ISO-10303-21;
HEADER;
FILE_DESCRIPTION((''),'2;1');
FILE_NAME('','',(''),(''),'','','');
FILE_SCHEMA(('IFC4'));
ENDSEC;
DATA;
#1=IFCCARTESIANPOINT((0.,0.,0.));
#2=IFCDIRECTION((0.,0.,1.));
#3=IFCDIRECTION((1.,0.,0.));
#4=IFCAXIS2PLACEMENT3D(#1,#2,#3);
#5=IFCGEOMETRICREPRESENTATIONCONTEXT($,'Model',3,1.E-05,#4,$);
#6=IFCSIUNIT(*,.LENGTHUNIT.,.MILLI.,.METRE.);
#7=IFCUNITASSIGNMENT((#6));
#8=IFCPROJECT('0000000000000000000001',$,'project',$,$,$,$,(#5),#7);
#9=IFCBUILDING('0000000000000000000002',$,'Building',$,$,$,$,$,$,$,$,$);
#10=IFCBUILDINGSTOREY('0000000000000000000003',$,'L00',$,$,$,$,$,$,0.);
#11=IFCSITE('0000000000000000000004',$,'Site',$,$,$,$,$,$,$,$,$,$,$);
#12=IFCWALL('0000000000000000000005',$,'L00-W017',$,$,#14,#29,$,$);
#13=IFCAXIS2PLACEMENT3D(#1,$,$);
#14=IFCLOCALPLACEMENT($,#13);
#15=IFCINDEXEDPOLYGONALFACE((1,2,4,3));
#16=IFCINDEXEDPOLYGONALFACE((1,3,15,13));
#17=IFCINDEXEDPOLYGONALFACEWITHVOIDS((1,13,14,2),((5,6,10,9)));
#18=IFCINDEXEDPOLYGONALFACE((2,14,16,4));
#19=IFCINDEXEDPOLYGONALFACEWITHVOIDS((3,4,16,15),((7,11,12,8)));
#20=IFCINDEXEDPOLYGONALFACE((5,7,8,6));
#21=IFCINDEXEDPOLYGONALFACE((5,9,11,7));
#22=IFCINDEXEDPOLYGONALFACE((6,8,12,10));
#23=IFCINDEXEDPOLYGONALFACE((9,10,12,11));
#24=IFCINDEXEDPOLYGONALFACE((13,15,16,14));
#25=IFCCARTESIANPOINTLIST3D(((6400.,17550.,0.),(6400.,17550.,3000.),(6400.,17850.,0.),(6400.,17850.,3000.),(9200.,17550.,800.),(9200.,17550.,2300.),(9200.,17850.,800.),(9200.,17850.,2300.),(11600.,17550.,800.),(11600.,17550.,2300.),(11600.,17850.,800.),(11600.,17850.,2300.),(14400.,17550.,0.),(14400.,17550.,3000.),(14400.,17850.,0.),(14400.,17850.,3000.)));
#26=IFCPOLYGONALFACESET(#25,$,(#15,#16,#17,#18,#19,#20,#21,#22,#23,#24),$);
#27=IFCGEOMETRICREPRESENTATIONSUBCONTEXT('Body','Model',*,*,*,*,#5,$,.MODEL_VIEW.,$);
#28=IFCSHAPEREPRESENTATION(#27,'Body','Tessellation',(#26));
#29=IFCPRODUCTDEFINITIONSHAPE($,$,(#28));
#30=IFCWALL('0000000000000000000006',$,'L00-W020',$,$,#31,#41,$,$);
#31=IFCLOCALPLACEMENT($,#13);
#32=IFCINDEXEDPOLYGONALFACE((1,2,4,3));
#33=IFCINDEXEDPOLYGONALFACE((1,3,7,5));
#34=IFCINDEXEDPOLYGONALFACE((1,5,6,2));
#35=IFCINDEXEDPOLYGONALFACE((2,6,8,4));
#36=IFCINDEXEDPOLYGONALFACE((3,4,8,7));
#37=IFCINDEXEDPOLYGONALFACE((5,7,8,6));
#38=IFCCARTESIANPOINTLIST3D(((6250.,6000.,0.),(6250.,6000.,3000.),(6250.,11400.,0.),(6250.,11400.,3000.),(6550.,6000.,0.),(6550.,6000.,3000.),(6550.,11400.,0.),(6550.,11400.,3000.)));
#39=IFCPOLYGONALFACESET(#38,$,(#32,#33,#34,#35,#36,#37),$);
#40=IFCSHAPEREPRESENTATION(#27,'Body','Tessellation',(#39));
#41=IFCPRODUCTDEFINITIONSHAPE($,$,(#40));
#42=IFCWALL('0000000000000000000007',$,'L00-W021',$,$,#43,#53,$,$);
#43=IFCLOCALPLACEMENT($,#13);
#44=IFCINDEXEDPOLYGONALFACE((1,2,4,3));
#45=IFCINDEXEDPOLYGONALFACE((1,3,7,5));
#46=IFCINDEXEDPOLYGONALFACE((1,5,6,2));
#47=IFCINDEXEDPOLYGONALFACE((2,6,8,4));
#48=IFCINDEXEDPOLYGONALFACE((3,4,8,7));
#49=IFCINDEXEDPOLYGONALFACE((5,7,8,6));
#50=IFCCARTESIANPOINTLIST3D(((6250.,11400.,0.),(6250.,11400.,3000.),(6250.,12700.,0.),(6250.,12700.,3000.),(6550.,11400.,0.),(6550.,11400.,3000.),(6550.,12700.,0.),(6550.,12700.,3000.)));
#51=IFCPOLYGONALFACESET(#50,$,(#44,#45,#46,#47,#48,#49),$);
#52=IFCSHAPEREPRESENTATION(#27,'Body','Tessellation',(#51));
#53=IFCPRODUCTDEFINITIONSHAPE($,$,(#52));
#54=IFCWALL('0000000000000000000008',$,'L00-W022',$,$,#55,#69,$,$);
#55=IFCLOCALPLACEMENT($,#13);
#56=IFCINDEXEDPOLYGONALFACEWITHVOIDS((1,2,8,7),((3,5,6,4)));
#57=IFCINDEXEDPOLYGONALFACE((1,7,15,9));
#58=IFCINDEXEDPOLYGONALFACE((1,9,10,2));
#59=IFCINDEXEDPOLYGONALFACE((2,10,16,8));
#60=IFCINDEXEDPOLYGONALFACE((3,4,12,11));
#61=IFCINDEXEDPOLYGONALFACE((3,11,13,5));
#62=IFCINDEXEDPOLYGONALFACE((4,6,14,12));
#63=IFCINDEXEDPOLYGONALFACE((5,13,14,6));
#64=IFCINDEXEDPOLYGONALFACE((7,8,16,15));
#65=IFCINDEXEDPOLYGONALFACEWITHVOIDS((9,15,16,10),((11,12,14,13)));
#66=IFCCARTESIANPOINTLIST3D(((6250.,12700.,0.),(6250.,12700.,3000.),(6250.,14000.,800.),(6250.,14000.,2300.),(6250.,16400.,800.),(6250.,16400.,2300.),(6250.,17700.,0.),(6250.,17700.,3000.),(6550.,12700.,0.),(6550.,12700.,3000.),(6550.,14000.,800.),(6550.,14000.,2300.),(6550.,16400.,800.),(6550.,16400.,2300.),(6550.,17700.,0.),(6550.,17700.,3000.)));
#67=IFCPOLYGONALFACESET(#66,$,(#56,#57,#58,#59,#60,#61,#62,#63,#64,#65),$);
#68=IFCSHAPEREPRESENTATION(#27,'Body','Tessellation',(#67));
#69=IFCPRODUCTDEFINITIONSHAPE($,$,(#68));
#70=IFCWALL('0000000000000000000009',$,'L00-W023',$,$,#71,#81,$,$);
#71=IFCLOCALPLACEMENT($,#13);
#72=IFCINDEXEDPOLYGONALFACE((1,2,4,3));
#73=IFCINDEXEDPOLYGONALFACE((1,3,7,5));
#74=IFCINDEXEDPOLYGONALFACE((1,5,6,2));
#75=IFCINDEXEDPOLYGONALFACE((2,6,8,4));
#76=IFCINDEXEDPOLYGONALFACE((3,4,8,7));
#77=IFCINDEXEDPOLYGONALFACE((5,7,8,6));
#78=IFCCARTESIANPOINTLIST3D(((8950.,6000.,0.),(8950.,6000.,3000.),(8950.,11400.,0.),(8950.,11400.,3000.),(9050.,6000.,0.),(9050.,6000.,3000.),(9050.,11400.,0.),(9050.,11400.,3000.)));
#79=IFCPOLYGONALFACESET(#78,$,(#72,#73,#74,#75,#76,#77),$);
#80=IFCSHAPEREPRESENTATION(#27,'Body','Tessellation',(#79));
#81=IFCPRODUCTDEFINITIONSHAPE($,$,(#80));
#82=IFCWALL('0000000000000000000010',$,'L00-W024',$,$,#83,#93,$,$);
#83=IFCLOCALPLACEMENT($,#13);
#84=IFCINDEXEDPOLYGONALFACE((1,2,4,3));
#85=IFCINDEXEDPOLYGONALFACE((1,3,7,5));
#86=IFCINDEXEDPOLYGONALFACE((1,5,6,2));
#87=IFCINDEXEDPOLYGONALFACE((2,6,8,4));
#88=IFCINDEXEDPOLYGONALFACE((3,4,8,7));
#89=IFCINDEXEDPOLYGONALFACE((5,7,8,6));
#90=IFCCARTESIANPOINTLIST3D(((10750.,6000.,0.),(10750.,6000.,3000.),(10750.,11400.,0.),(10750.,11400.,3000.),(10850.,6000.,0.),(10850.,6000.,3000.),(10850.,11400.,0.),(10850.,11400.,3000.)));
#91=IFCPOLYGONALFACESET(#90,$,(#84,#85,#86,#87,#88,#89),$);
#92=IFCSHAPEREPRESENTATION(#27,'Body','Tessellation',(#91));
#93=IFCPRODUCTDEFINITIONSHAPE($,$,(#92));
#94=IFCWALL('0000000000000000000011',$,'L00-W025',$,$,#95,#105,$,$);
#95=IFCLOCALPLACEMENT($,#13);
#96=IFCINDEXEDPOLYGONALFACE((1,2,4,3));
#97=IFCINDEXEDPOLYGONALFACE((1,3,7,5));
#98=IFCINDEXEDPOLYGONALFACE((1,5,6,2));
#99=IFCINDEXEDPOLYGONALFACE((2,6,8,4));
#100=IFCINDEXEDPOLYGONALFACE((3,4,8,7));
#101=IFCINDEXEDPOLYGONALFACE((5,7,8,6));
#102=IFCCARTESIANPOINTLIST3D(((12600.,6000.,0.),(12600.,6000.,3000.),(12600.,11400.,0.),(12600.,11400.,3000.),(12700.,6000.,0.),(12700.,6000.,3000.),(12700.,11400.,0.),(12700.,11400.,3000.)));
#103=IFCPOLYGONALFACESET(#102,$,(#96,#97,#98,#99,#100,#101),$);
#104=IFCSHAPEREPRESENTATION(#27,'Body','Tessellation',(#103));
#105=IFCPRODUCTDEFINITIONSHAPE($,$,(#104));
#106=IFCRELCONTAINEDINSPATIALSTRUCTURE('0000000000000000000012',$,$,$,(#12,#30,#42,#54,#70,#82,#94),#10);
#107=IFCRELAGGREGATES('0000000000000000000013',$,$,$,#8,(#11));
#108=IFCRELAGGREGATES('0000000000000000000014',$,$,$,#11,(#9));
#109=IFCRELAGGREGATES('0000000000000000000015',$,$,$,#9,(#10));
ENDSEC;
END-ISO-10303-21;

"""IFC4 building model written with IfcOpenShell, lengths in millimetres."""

from ifc_helpers import new_model, si_unit, frame, origin_with_axes, place, context, subcontext, project, spatial, indexed_curve, outline, extrude, element, save


model = new_model("IFC4")

# Units and contexts
model_context = context("Model", 3, precision=1e-05, world=origin_with_axes())
body_context = subcontext(model_context, "Body", "Model", "MODEL_VIEW")
ifc_project = project(units=[si_unit("LENGTHUNIT", "METRE", prefix="MILLI")], contexts=[model_context])

# Site, building, storey
site = spatial("IfcSite", under=ifc_project, Name="Site")
building = spatial("IfcBuilding", under=site, Name="Building")
storey = spatial("IfcBuildingStorey", under=building, Name="L00", Elevation=0.0)

# Wall, opening
wall_1_placement = place(None, frame((6400.0, 17550.0, 0.0), z_axis=(0.0, 0.0, 1.0), x_axis=(1.0, 0.0, 0.0)))
wall_1 = element("IfcWall", 1, at=wall_1_placement, inside=storey, Name="L00-W017", context=body_context, shape_type="SweptSolid", body=[
    extrude(outline(indexed_curve([(0.0, 0.0), (0.0, 300.0), (8000.0, 300.0), (8000.0, 0.0), (0.0, 0.0)], self_intersect=False)), origin_with_axes(), (0.0, 0.0, 1.0), 3000.0),
])
opening_1_placement = place(wall_1_placement, frame((2800.0, -10.0, 800.0), z_axis=(0.0, 0.0, 1.0), x_axis=(1.0, 0.0, 0.0)))
element("IfcOpeningElement", 2, at=opening_1_placement, cuts=wall_1, context=body_context, shape_type="SweptSolid", body=[
    extrude(outline(indexed_curve([(0.0, 0.0), (0.0, 320.0), (2400.0, 320.0), (2400.0, 0.0), (0.0, 0.0)], self_intersect=False)), origin_with_axes(), (0.0, 0.0, 1.0), 1500.0),
])

# Walls
wall_2_placement = place(None, frame((6550.0, 6000.0, 0.0), z_axis=(0.0, 0.0, 1.0), x_axis=(0.0, 1.0, 0.0)))
element("IfcWall", 3, at=wall_2_placement, inside=storey, Name="L00-W020", context=body_context, shape_type="SweptSolid", body=[
    extrude(outline(indexed_curve([(0.0, 0.0), (0.0, 300.0), (5400.0, 300.0), (5400.0, 0.0), (0.0, 0.0)], self_intersect=False)), origin_with_axes(), (0.0, 0.0, 1.0), 3000.0),
])
wall_3_placement = place(None, frame((6550.0, 11400.0, 0.0), z_axis=(0.0, 0.0, 1.0), x_axis=(0.0, 1.0, 0.0)))
element("IfcWall", 4, at=wall_3_placement, inside=storey, Name="L00-W021", context=body_context, shape_type="SweptSolid", body=[
    extrude(outline(indexed_curve([(0.0, 0.0), (0.0, 300.0), (1300.0, 300.0), (1300.0, 0.0), (0.0, 0.0)], self_intersect=False)), origin_with_axes(), (0.0, 0.0, 1.0), 3000.0),
])

# Wall, opening
wall_4_placement = place(None, frame((6550.0, 12700.0, 0.0), z_axis=(0.0, 0.0, 1.0), x_axis=(0.0, 1.0, 0.0)))
wall_4 = element("IfcWall", 5, at=wall_4_placement, inside=storey, Name="L00-W022", context=body_context, shape_type="SweptSolid", body=[
    extrude(outline(indexed_curve([(0.0, 0.0), (0.0, 300.0), (5000.0, 300.0), (5000.0, 0.0), (0.0, 0.0)], self_intersect=False)), origin_with_axes(), (0.0, 0.0, 1.0), 3000.0),
])
opening_2_placement = place(wall_4_placement, frame((1300.0, -10.0, 800.0), z_axis=(0.0, 0.0, 1.0), x_axis=(1.0, 0.0, 0.0)))
element("IfcOpeningElement", 6, at=opening_2_placement, cuts=wall_4, context=body_context, shape_type="SweptSolid", body=[
    extrude(outline(indexed_curve([(0.0, 0.0), (0.0, 320.0), (2400.0, 320.0), (2400.0, 0.0), (0.0, 0.0)], self_intersect=False)), origin_with_axes(), (0.0, 0.0, 1.0), 1500.0),
])

# Walls
for number, where, z_axis, x_axis, name in (
    (7, (9050.0, 6000.0, 0.0), (0.0, 0.0, 1.0), (0.0, 1.0, 0.0), "L00-W023"),
    (8, (10850.0, 6000.0, 0.0), (0.0, 0.0, 1.0), (0.0, 1.0, 0.0), "L00-W024"),
    (9, (12700.0, 6000.0, 0.0), (0.0, 0.0, 1.0), (0.0, 1.0, 0.0), "L00-W025"),
):
    element("IfcWall", number, at=place(None, frame(where, z_axis=z_axis, x_axis=x_axis)), inside=storey, Name=name, context=body_context, shape_type="SweptSolid", body=[
        extrude(outline(indexed_curve([(0.0, 0.0), (0.0, 100.0), (5400.0, 100.0), (5400.0, 0.0), (0.0, 0.0)], self_intersect=False)), origin_with_axes(), (0.0, 0.0, 1.0), 3000.0),
    ])

save(model, "model.ifc")
